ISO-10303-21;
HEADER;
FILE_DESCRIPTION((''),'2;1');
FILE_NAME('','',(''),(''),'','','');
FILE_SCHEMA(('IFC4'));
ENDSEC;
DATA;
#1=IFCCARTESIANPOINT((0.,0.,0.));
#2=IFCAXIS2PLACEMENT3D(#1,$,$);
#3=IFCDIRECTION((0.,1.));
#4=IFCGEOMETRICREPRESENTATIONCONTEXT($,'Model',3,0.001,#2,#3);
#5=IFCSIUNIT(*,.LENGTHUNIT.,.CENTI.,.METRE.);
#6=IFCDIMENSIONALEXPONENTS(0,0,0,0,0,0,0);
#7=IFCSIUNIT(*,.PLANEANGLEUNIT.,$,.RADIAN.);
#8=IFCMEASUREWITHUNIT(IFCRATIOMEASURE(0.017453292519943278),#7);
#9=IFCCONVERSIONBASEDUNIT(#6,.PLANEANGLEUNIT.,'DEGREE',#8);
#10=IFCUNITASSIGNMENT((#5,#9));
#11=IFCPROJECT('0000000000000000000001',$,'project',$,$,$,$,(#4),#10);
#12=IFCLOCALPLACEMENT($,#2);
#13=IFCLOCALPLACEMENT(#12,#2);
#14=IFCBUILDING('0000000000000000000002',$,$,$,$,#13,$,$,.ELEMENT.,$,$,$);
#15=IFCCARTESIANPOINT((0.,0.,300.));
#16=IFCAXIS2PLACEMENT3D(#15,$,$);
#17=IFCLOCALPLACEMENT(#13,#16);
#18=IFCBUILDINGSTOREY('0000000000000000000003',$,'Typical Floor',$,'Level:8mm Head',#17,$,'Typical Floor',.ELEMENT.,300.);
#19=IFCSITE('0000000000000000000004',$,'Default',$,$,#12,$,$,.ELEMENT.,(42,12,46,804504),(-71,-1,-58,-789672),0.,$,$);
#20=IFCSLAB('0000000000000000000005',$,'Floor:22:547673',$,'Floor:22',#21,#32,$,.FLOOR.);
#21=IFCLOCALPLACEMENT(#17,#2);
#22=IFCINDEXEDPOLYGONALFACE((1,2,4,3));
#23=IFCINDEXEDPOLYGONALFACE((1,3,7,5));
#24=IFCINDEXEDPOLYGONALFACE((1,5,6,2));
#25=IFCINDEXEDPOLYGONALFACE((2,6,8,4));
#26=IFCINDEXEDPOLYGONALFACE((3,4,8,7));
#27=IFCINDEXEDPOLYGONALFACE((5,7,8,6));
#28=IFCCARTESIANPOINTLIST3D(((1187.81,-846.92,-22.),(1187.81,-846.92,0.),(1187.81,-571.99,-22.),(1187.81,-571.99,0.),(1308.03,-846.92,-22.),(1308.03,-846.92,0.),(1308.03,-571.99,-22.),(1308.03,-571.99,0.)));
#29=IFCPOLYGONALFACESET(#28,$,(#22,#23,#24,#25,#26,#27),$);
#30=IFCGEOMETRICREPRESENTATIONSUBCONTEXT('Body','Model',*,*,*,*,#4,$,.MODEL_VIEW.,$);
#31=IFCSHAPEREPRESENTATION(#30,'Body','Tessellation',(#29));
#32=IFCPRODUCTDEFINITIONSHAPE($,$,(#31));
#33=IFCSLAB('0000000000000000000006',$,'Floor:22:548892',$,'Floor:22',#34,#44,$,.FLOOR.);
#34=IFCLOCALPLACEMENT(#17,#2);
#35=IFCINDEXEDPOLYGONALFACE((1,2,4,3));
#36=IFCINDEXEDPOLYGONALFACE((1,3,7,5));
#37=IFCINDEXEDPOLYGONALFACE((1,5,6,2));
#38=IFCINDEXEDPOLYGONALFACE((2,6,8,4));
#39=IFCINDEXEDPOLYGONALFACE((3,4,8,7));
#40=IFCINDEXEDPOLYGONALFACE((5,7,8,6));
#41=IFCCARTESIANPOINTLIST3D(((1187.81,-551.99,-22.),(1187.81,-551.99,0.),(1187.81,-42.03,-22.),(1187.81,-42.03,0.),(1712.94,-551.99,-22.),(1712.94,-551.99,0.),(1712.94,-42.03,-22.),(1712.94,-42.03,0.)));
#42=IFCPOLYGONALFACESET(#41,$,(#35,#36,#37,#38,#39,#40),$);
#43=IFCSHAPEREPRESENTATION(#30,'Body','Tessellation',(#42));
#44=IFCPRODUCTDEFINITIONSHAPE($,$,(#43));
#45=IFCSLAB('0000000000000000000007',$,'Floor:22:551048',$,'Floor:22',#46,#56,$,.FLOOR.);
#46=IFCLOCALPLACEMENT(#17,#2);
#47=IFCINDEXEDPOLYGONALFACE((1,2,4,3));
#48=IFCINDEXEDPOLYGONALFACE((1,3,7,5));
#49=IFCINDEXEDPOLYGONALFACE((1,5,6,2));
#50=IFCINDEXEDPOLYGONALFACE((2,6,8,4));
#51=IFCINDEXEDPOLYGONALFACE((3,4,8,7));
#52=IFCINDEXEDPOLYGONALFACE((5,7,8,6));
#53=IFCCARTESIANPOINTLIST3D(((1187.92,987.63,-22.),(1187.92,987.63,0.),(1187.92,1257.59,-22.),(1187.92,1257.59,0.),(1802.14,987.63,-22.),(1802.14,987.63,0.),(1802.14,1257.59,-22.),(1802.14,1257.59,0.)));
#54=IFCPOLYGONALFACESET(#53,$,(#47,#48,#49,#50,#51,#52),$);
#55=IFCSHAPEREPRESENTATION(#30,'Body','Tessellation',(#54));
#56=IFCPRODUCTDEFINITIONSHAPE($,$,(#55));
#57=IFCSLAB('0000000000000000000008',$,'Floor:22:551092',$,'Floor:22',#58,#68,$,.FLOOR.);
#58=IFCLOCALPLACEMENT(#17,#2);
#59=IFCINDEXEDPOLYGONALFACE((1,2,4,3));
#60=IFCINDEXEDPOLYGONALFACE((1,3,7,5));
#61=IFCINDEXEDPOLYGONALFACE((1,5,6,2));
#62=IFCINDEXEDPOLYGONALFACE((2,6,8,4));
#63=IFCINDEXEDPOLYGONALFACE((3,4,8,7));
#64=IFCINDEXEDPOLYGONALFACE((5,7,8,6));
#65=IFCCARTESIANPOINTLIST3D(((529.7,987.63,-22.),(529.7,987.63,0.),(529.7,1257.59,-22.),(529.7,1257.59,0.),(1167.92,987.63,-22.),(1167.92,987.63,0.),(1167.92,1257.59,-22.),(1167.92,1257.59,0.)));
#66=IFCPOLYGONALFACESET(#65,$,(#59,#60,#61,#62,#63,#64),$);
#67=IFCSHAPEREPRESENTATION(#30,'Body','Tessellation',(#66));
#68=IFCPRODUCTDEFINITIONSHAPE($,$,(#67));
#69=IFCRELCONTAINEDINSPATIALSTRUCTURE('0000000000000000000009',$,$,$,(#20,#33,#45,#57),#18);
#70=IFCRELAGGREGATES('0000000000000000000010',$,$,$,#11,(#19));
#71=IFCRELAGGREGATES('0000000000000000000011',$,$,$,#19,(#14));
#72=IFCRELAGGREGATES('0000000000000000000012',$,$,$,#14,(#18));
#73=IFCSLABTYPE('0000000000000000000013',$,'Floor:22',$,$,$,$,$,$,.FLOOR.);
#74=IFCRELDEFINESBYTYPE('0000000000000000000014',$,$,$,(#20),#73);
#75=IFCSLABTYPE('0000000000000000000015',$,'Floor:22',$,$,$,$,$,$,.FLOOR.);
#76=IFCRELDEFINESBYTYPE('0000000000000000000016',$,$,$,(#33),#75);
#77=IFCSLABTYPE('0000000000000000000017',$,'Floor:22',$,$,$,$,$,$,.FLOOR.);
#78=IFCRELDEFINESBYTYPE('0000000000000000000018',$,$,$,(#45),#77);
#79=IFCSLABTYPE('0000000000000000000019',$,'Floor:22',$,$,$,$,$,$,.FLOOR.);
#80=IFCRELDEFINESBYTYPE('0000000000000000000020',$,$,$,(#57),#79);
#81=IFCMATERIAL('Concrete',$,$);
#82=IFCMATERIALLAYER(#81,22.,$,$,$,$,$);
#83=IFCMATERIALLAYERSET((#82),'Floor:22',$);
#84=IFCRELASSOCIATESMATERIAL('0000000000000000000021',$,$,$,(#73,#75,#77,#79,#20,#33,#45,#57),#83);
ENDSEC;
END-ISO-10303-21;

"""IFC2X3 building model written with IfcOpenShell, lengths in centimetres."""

from ifc_helpers import new_model, entity, si_unit, converted_unit, direction, frame, frame_2d, origin, place, context, subcontext, project, spatial, rectangle, extrude, material, layer, layer_set, layer_usage, type_object, element, save


model = new_model("IFC2X3")

# Units and contexts
model_context = context("Model", 3, precision=0.001, world=origin(), true_north=direction((0.0, 1.0)))
body_context = subcontext(model_context, "Body", "Model", "MODEL_VIEW")
ifc_project = project(units=[si_unit("LENGTHUNIT", "METRE", prefix="CENTI"), converted_unit("PLANEANGLEUNIT", "DEGREE", entity("IfcRatioMeasure", 0.017453292519943278), si_unit("PLANEANGLEUNIT", "RADIAN"), dimensions=[0, 0, 0, 0, 0, 0, 0])], contexts=[model_context])

# Site, building, storey
site_placement = place(None, origin())
site = spatial("IfcSite", under=ifc_project, at=site_placement, Name="Default", CompositionType="ELEMENT", RefLatitude=(42, 12, 46, 804504), RefLongitude=(-71, -1, -58, -789672), RefElevation=0.0)
building_placement = place(site_placement, origin())
building = spatial("IfcBuilding", under=site, at=building_placement, CompositionType="ELEMENT")
storey_placement = place(building_placement, frame((0.0, 0.0, 300.0)))
storey = spatial("IfcBuildingStorey", under=building, at=storey_placement, Name="Typical Floor", ObjectType="Level:8mm Head", LongName="Typical Floor", CompositionType="ELEMENT", Elevation=300.0)

# Shared definitions
ifc_material = material(Name="Concrete")

# Slabs
ifc_layer = layer(ifc_material, 22.0)
ifc_layer_set = layer_set([ifc_layer], Name="Floor:22")
ifc_layer_usage_1 = layer_usage(ifc_layer_set, "AXIS3", "POSITIVE", 0.0)
slab_type_1 = type_object("IfcSlabType", Name="Floor:22", PredefinedType="FLOOR", material=ifc_layer_set)
slab_1_placement = place(storey_placement, origin())
element("IfcSlab", 1, at=slab_1_placement, inside=storey, type_object=slab_type_1, material=ifc_layer_usage_1, Name="Floor:22:547673", ObjectType="Floor:22", PredefinedType="FLOOR", context=body_context, shape_type="SweptSolid", body=[
    extrude(rectangle(XDim=274.93, YDim=120.22, at=frame_2d((0.0, 0.0), x_axis=(1.0, 0.0))), frame((1247.92, -709.46, 0.0), z_axis=(0.0, 0.0, -1.0), x_axis=(0.0, 1.0, 0.0)), (0.0, 0.0, 1.0), 22.0),
])
ifc_layer_usage_2 = layer_usage(ifc_layer_set, "AXIS3", "POSITIVE", 0.0)
slab_type_2 = type_object("IfcSlabType", Name="Floor:22", PredefinedType="FLOOR", material=ifc_layer_set)
slab_2_placement = place(storey_placement, origin())
element("IfcSlab", 2, at=slab_2_placement, inside=storey, type_object=slab_type_2, material=ifc_layer_usage_2, Name="Floor:22:548892", ObjectType="Floor:22", PredefinedType="FLOOR", context=body_context, shape_type="SweptSolid", body=[
    extrude(rectangle(XDim=509.96, YDim=525.12, at=frame_2d((0.0, 0.0), x_axis=(1.0, 0.0))), frame((1450.38, -297.01, 0.0), z_axis=(0.0, 0.0, -1.0), x_axis=(0.0, 1.0, 0.0)), (0.0, 0.0, 1.0), 22.0),
])
ifc_layer_usage_3 = layer_usage(ifc_layer_set, "AXIS3", "POSITIVE", 0.0)
slab_type_3 = type_object("IfcSlabType", Name="Floor:22", PredefinedType="FLOOR", material=ifc_layer_set)
slab_3_placement = place(storey_placement, origin())
element("IfcSlab", 3, at=slab_3_placement, inside=storey, type_object=slab_type_3, material=ifc_layer_usage_3, Name="Floor:22:551048", ObjectType="Floor:22", PredefinedType="FLOOR", context=body_context, shape_type="SweptSolid", body=[
    extrude(rectangle(XDim=269.96, YDim=614.22, at=frame_2d((0.0, 0.0), x_axis=(1.0, 0.0))), frame((1495.03, 1122.61, 0.0), z_axis=(0.0, 0.0, -1.0), x_axis=(0.0, 1.0, 0.0)), (0.0, 0.0, 1.0), 22.0),
])
ifc_layer_usage_4 = layer_usage(ifc_layer_set, "AXIS3", "POSITIVE", 0.0)
slab_type_4 = type_object("IfcSlabType", Name="Floor:22", PredefinedType="FLOOR", material=ifc_layer_set)
slab_4_placement = place(storey_placement, origin())
element("IfcSlab", 4, at=slab_4_placement, inside=storey, type_object=slab_type_4, material=ifc_layer_usage_4, Name="Floor:22:551092", ObjectType="Floor:22", PredefinedType="FLOOR", context=body_context, shape_type="SweptSolid", body=[
    extrude(rectangle(XDim=269.96, YDim=638.22, at=frame_2d((0.0, 0.0), x_axis=(1.0, 0.0))), frame((848.81, 1122.61, 0.0), z_axis=(0.0, 0.0, -1.0), x_axis=(0.0, 1.0, 0.0)), (0.0, 0.0, 1.0), 22.0),
])

save(model, "model.ifc")
